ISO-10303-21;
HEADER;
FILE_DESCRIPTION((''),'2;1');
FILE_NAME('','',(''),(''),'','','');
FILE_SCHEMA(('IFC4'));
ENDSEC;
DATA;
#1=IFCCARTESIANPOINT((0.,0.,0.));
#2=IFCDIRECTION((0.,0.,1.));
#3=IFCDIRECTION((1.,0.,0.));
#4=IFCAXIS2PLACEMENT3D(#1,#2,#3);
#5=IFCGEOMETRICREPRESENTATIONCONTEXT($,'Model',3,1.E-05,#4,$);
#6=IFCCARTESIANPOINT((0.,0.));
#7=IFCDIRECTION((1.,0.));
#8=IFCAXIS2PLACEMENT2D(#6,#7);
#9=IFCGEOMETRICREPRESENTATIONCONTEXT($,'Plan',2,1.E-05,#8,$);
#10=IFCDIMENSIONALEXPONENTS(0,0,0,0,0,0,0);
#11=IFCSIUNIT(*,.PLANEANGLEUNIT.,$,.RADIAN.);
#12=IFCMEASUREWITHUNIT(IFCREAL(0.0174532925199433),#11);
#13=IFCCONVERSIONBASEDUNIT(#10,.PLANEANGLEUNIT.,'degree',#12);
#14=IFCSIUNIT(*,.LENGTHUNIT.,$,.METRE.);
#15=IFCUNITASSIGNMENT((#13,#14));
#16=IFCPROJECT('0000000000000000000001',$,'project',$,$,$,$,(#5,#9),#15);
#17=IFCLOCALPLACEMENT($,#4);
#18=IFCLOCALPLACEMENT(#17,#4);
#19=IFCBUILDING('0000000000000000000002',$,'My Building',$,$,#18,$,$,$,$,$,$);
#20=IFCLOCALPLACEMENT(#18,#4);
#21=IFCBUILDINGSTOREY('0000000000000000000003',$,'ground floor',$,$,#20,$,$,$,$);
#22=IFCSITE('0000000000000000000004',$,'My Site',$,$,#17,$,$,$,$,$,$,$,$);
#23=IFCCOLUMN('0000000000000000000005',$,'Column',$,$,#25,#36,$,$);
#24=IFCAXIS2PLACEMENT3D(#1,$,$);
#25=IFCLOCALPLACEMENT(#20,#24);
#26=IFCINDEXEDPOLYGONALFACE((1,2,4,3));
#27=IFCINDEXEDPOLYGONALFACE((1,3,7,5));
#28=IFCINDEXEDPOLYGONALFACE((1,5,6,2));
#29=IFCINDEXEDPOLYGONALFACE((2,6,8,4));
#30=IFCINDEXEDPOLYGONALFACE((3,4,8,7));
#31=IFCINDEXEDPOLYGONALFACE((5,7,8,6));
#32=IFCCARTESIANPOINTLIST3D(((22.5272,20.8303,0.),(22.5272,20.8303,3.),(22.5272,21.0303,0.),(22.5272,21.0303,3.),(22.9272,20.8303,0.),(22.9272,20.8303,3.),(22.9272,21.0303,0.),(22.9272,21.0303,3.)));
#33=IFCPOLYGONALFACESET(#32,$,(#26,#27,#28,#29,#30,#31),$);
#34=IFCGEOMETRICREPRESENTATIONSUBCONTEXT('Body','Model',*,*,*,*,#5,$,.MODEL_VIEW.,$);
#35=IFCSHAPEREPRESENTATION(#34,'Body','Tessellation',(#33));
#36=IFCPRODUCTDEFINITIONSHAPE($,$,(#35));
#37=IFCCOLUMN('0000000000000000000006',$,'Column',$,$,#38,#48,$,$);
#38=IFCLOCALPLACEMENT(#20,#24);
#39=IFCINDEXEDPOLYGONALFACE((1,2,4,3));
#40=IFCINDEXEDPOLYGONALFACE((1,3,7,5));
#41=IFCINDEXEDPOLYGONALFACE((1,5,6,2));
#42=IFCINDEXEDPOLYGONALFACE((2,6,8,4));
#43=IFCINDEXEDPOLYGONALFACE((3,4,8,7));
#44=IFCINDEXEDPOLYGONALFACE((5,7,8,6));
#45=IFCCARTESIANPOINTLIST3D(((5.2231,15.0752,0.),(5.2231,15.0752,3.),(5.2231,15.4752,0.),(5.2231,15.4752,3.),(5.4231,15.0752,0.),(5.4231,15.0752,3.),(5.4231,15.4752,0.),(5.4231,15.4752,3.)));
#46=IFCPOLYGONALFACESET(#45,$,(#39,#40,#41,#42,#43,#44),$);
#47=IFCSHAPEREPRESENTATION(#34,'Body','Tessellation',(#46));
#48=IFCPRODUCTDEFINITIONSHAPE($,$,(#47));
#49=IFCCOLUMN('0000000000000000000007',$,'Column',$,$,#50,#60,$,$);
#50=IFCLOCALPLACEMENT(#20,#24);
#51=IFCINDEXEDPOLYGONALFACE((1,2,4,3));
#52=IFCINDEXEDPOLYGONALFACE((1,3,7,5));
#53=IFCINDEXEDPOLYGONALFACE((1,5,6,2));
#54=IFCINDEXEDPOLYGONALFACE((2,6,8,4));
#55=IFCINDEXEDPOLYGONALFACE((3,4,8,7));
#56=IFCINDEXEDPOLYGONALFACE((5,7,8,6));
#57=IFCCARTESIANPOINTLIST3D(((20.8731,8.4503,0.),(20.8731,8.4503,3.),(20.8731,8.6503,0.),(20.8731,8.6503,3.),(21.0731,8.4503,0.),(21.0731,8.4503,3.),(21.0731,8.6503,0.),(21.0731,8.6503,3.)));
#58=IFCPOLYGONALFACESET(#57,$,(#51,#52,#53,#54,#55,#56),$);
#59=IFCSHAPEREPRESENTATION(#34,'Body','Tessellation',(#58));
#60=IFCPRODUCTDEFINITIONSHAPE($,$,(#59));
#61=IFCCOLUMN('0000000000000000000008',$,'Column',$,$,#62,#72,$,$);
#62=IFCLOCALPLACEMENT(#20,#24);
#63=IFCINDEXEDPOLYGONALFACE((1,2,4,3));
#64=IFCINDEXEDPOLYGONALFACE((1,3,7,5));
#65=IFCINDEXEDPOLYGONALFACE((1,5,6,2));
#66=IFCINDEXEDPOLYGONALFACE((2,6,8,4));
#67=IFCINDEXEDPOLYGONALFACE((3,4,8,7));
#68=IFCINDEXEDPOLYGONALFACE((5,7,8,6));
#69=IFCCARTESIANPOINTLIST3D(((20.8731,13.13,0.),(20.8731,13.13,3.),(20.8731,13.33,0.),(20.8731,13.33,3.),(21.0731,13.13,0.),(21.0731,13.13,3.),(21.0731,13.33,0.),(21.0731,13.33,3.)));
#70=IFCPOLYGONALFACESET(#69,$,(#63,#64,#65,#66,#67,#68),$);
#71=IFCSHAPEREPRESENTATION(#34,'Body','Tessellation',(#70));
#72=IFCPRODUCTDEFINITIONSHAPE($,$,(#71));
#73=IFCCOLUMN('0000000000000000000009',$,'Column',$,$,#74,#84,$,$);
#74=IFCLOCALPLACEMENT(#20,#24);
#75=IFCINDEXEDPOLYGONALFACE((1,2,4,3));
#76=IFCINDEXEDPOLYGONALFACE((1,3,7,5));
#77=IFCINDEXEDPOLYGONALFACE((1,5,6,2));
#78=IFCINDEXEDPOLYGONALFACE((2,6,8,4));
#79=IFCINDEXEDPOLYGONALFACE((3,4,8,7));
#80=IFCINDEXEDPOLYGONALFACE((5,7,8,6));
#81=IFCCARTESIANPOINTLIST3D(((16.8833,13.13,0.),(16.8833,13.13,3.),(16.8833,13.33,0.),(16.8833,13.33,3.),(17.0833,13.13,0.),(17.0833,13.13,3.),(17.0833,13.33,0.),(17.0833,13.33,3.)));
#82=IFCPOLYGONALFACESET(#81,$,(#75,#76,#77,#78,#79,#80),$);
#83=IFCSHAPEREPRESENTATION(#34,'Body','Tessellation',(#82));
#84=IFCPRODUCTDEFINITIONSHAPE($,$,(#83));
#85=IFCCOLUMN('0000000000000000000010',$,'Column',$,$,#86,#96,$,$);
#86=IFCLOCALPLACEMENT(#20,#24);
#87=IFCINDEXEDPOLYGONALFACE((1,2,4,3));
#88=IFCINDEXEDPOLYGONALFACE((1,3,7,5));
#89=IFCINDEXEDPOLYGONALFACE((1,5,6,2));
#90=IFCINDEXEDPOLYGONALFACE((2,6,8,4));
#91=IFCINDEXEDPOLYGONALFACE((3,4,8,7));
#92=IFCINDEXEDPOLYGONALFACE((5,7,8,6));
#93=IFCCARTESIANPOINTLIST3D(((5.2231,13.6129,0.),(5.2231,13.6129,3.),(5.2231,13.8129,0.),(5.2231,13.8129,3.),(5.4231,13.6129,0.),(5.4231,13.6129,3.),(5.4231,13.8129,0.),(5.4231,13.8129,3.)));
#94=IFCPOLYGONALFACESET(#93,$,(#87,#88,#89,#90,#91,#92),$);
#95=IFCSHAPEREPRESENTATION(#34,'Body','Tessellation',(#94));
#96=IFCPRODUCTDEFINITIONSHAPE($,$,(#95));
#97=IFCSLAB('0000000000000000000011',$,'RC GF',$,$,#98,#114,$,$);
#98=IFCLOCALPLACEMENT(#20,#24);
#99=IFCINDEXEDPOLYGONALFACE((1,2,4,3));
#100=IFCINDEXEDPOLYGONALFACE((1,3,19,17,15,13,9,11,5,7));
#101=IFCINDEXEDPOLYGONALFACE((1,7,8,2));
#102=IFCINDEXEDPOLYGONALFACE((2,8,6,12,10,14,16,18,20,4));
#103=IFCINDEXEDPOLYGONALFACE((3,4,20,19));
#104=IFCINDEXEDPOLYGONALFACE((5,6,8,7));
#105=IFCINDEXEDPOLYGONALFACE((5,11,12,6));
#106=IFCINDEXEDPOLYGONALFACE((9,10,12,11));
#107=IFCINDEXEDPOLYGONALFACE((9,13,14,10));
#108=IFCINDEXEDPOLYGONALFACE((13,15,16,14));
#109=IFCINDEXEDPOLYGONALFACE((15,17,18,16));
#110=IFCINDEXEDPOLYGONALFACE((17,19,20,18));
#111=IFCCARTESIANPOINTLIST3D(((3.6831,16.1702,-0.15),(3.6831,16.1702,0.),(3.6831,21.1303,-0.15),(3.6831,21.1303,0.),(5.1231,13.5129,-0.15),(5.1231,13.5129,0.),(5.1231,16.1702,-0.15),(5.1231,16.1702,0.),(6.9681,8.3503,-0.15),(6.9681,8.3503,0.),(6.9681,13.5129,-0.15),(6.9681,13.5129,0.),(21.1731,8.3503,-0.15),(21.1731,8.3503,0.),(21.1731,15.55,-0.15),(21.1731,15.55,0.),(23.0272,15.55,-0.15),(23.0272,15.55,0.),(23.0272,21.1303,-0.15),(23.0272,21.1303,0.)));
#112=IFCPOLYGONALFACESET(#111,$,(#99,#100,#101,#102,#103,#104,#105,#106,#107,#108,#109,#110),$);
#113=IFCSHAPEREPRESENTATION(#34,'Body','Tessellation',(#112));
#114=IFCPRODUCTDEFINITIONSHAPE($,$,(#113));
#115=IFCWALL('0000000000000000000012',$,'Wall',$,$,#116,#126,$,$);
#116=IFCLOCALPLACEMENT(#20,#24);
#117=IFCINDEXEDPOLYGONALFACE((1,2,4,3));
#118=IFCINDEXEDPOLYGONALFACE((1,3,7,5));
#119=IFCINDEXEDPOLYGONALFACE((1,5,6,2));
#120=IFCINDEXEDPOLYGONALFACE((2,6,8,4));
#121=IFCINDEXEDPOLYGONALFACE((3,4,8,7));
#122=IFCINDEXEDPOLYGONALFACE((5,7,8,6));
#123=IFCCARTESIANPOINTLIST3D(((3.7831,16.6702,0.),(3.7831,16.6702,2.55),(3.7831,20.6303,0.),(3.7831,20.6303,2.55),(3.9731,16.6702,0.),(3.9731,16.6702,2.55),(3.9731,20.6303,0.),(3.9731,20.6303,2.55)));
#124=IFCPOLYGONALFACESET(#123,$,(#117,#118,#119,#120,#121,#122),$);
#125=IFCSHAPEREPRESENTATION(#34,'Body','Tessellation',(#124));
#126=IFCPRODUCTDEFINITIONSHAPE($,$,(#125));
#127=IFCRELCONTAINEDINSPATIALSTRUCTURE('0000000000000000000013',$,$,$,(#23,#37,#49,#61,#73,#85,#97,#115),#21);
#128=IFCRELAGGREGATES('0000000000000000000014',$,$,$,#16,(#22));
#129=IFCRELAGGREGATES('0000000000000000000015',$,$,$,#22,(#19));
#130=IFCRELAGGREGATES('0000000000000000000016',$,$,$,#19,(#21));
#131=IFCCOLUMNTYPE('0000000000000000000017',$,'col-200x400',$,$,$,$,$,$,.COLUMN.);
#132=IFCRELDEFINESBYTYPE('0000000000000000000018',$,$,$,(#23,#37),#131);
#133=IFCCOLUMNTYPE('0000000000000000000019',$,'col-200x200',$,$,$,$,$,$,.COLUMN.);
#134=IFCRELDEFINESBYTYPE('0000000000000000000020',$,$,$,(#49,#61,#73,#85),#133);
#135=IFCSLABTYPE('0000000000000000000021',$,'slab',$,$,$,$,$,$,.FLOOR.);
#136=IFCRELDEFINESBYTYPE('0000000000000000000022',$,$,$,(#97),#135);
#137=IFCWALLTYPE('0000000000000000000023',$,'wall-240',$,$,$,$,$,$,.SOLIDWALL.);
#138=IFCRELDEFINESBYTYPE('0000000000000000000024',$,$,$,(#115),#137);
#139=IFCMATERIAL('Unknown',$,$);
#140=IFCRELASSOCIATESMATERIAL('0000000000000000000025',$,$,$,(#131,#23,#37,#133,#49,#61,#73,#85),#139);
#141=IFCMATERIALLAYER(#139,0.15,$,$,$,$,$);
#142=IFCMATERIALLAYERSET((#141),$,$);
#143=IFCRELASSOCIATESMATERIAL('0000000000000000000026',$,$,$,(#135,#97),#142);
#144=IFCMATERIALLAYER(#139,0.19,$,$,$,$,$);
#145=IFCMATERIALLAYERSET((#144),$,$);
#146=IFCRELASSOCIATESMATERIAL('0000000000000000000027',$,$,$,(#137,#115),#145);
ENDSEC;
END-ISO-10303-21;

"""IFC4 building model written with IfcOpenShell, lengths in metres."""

from ifc_helpers import new_model, entity, si_unit, converted_unit, frame, origin_with_axes, origin_2d_with_axis, place, context, subcontext, project, spatial, line, indexed_curve, rectangle, outline, extrude, material, layer, layer_set, layer_usage, material_profile, profile_set, profile_usage, type_object, element, save


model = new_model("IFC4")

# Units and contexts
model_context = context("Model", 3, precision=1e-05, world=origin_with_axes())
plan_context = context("Plan", 2, precision=1e-05, world=origin_2d_with_axis())
body_context = subcontext(model_context, "Body", "Model", "MODEL_VIEW")
ifc_project = project(units=[converted_unit("PLANEANGLEUNIT", "degree", entity("IfcReal", 0.0174532925199433), si_unit("PLANEANGLEUNIT", "RADIAN"), dimensions=[0, 0, 0, 0, 0, 0, 0]), si_unit("LENGTHUNIT", "METRE")], contexts=[model_context, plan_context])

# Site, building, storey
site_placement = place(None, origin_with_axes())
site = spatial("IfcSite", under=ifc_project, at=site_placement, Name="My Site")
building_placement = place(site_placement, origin_with_axes())
building = spatial("IfcBuilding", under=site, at=building_placement, Name="My Building")
storey_placement = place(building_placement, origin_with_axes())
storey = spatial("IfcBuildingStorey", under=building, at=storey_placement, Name="ground floor")

# Columns
ifc_material = material(Name="Unknown")
ifc_material_profile_1 = material_profile(ifc_material, rectangle(XDim=0.2, YDim=0.4))
ifc_profile_set_1 = profile_set([ifc_material_profile_1])
column_type_1 = type_object("IfcColumnType", Name="col-200x400", PredefinedType="COLUMN", material=ifc_profile_set_1)
ifc_profile_usage_1 = profile_usage(ifc_profile_set_1, cardinal=1)
column_1_placement = place(storey_placement, frame((22.5272, 20.8303, 0.0), z_axis=(0.0, 0.0, 1.0), x_axis=(0.0, -1.0, 0.0)))
element("IfcColumn", 1, at=column_1_placement, inside=storey, type_object=column_type_1, material=ifc_profile_usage_1, Name="Column", context=body_context, shape_type="SweptSolid", body=[
    extrude(rectangle(XDim=0.2, YDim=0.4), frame((-0.1, 0.2, 0.0), z_axis=(0.0, 0.0, 1.0), x_axis=(1.0, 0.0, 0.0)), (0.0, 0.0, 1.0), 3.0),
])
ifc_profile_usage_2 = profile_usage(ifc_profile_set_1, cardinal=1)
column_2_placement = place(storey_placement, frame((5.4231, 15.0752, 0.0), z_axis=(0.0, 0.0, 1.0), x_axis=(1.0, 0.0, 0.0)))
element("IfcColumn", 2, at=column_2_placement, inside=storey, type_object=column_type_1, material=ifc_profile_usage_2, Name="Column", context=body_context, shape_type="SweptSolid", body=[
    extrude(rectangle(XDim=0.2, YDim=0.4), frame((-0.1, 0.2, 0.0), z_axis=(0.0, 0.0, 1.0), x_axis=(1.0, 0.0, 0.0)), (0.0, 0.0, 1.0), 3.0),
])
ifc_material_profile_2 = material_profile(ifc_material, rectangle(XDim=0.2, YDim=0.2))
ifc_profile_set_2 = profile_set([ifc_material_profile_2])
ifc_profile_usage_3 = profile_usage(ifc_profile_set_2, cardinal=1)
column_type_2 = type_object("IfcColumnType", Name="col-200x200", PredefinedType="COLUMN", material=ifc_profile_set_2)
column_3_placement = place(storey_placement, frame((21.0731, 8.4503, 0.0), z_axis=(0.0, 0.0, 1.0), x_axis=(1.0, 0.0, 0.0)))
element("IfcColumn", 3, at=column_3_placement, inside=storey, type_object=column_type_2, material=ifc_profile_usage_3, Name="Column", context=body_context, shape_type="SweptSolid", body=[
    extrude(rectangle(XDim=0.2, YDim=0.2), frame((-0.1, 0.1, 0.0), z_axis=(0.0, 0.0, 1.0), x_axis=(1.0, 0.0, 0.0)), (0.0, 0.0, 1.0), 3.0),
])
ifc_profile_usage_4 = profile_usage(ifc_profile_set_2, cardinal=1)
column_4_placement = place(storey_placement, frame((21.0731, 13.13, 0.0), z_axis=(0.0, 0.0, 1.0), x_axis=(1.0, 0.0, 0.0)))
element("IfcColumn", 4, at=column_4_placement, inside=storey, type_object=column_type_2, material=ifc_profile_usage_4, Name="Column", context=body_context, shape_type="SweptSolid", body=[
    extrude(rectangle(XDim=0.2, YDim=0.2), frame((-0.1, 0.1, 0.0), z_axis=(0.0, 0.0, 1.0), x_axis=(1.0, 0.0, 0.0)), (0.0, 0.0, 1.0), 3.0),
])
ifc_profile_usage_5 = profile_usage(ifc_profile_set_2, cardinal=1)
column_5_placement = place(storey_placement, frame((17.0833, 13.13, 0.0), z_axis=(0.0, 0.0, 1.0), x_axis=(1.0, 0.0, 0.0)))
element("IfcColumn", 5, at=column_5_placement, inside=storey, type_object=column_type_2, material=ifc_profile_usage_5, Name="Column", context=body_context, shape_type="SweptSolid", body=[
    extrude(rectangle(XDim=0.2, YDim=0.2), frame((-0.1, 0.1, 0.0), z_axis=(0.0, 0.0, 1.0), x_axis=(1.0, 0.0, 0.0)), (0.0, 0.0, 1.0), 3.0),
])
ifc_profile_usage_6 = profile_usage(ifc_profile_set_2, cardinal=1)
column_6_placement = place(storey_placement, frame((5.4231, 13.6129, 0.0), z_axis=(0.0, 0.0, 1.0), x_axis=(1.0, 0.0, 0.0)))
element("IfcColumn", 6, at=column_6_placement, inside=storey, type_object=column_type_2, material=ifc_profile_usage_6, Name="Column", context=body_context, shape_type="SweptSolid", body=[
    extrude(rectangle(XDim=0.2, YDim=0.2), frame((-0.1, 0.1, 0.0), z_axis=(0.0, 0.0, 1.0), x_axis=(1.0, 0.0, 0.0)), (0.0, 0.0, 1.0), 3.0),
])

# Slab
ifc_layer_1 = layer(ifc_material, 0.15)
ifc_layer_set_1 = layer_set([ifc_layer_1])
ifc_layer_usage_1 = layer_usage(ifc_layer_set_1, "AXIS3", "POSITIVE", 0.0)
slab_type = type_object("IfcSlabType", Name="slab", PredefinedType="FLOOR", material=ifc_layer_set_1)
slab_placement = place(storey_placement, frame((6.9681, 8.3503, -0.15), z_axis=(0.0, 0.0, 1.0), x_axis=(1.0, 0.0, 0.0)))
element("IfcSlab", 7, at=slab_placement, inside=storey, type_object=slab_type, material=ifc_layer_usage_1, Name="RC GF", context=body_context, shape_type="SweptSolid", body=[
    extrude(outline(indexed_curve([(16.0591, 12.78), (14.205, 0.0), (0.0, 0.0), (-3.285, 12.78), (0.0, 5.1626), (-1.845, 5.1626), (-1.845, 7.8199), (-3.285, 7.8199), (14.205, 7.1996), (16.0591, 7.1996)], segments=[line(9, 10), line(10, 1), line(1, 4), line(4, 8), line(8, 7), line(7, 6), line(6, 5), line(5, 3), line(3, 2), line(2, 9)], self_intersect=False)), None, (0.0, 0.0, 1.0), 0.15),
])

# Wall
ifc_layer_2 = layer(ifc_material, 0.19)
ifc_layer_set_2 = layer_set([ifc_layer_2])
ifc_layer_usage_2 = layer_usage(ifc_layer_set_2, "AXIS2", "POSITIVE", 0.0)
wall_type = type_object("IfcWallType", Name="wall-240", PredefinedType="SOLIDWALL", material=ifc_layer_set_2)
wall_placement = place(storey_placement, frame((3.7831, 20.6303, 0.0), z_axis=(0.0, 0.0, 1.0), x_axis=(-0.000001, -1.0, 0.0)))
element("IfcWall", 8, at=wall_placement, inside=storey, type_object=wall_type, material=ifc_layer_usage_2, Name="Wall", context=body_context, shape_type="SweptSolid", body=[
    extrude(outline(indexed_curve([(0.0, 0.0), (0.0, 0.19), (3.9601, 0.19), (3.9601, 0.0), (0.0, 0.0)], self_intersect=False)), origin_with_axes(), (0.0, 0.0, 1.0), 2.55),
])

save(model, "model.ifc")
